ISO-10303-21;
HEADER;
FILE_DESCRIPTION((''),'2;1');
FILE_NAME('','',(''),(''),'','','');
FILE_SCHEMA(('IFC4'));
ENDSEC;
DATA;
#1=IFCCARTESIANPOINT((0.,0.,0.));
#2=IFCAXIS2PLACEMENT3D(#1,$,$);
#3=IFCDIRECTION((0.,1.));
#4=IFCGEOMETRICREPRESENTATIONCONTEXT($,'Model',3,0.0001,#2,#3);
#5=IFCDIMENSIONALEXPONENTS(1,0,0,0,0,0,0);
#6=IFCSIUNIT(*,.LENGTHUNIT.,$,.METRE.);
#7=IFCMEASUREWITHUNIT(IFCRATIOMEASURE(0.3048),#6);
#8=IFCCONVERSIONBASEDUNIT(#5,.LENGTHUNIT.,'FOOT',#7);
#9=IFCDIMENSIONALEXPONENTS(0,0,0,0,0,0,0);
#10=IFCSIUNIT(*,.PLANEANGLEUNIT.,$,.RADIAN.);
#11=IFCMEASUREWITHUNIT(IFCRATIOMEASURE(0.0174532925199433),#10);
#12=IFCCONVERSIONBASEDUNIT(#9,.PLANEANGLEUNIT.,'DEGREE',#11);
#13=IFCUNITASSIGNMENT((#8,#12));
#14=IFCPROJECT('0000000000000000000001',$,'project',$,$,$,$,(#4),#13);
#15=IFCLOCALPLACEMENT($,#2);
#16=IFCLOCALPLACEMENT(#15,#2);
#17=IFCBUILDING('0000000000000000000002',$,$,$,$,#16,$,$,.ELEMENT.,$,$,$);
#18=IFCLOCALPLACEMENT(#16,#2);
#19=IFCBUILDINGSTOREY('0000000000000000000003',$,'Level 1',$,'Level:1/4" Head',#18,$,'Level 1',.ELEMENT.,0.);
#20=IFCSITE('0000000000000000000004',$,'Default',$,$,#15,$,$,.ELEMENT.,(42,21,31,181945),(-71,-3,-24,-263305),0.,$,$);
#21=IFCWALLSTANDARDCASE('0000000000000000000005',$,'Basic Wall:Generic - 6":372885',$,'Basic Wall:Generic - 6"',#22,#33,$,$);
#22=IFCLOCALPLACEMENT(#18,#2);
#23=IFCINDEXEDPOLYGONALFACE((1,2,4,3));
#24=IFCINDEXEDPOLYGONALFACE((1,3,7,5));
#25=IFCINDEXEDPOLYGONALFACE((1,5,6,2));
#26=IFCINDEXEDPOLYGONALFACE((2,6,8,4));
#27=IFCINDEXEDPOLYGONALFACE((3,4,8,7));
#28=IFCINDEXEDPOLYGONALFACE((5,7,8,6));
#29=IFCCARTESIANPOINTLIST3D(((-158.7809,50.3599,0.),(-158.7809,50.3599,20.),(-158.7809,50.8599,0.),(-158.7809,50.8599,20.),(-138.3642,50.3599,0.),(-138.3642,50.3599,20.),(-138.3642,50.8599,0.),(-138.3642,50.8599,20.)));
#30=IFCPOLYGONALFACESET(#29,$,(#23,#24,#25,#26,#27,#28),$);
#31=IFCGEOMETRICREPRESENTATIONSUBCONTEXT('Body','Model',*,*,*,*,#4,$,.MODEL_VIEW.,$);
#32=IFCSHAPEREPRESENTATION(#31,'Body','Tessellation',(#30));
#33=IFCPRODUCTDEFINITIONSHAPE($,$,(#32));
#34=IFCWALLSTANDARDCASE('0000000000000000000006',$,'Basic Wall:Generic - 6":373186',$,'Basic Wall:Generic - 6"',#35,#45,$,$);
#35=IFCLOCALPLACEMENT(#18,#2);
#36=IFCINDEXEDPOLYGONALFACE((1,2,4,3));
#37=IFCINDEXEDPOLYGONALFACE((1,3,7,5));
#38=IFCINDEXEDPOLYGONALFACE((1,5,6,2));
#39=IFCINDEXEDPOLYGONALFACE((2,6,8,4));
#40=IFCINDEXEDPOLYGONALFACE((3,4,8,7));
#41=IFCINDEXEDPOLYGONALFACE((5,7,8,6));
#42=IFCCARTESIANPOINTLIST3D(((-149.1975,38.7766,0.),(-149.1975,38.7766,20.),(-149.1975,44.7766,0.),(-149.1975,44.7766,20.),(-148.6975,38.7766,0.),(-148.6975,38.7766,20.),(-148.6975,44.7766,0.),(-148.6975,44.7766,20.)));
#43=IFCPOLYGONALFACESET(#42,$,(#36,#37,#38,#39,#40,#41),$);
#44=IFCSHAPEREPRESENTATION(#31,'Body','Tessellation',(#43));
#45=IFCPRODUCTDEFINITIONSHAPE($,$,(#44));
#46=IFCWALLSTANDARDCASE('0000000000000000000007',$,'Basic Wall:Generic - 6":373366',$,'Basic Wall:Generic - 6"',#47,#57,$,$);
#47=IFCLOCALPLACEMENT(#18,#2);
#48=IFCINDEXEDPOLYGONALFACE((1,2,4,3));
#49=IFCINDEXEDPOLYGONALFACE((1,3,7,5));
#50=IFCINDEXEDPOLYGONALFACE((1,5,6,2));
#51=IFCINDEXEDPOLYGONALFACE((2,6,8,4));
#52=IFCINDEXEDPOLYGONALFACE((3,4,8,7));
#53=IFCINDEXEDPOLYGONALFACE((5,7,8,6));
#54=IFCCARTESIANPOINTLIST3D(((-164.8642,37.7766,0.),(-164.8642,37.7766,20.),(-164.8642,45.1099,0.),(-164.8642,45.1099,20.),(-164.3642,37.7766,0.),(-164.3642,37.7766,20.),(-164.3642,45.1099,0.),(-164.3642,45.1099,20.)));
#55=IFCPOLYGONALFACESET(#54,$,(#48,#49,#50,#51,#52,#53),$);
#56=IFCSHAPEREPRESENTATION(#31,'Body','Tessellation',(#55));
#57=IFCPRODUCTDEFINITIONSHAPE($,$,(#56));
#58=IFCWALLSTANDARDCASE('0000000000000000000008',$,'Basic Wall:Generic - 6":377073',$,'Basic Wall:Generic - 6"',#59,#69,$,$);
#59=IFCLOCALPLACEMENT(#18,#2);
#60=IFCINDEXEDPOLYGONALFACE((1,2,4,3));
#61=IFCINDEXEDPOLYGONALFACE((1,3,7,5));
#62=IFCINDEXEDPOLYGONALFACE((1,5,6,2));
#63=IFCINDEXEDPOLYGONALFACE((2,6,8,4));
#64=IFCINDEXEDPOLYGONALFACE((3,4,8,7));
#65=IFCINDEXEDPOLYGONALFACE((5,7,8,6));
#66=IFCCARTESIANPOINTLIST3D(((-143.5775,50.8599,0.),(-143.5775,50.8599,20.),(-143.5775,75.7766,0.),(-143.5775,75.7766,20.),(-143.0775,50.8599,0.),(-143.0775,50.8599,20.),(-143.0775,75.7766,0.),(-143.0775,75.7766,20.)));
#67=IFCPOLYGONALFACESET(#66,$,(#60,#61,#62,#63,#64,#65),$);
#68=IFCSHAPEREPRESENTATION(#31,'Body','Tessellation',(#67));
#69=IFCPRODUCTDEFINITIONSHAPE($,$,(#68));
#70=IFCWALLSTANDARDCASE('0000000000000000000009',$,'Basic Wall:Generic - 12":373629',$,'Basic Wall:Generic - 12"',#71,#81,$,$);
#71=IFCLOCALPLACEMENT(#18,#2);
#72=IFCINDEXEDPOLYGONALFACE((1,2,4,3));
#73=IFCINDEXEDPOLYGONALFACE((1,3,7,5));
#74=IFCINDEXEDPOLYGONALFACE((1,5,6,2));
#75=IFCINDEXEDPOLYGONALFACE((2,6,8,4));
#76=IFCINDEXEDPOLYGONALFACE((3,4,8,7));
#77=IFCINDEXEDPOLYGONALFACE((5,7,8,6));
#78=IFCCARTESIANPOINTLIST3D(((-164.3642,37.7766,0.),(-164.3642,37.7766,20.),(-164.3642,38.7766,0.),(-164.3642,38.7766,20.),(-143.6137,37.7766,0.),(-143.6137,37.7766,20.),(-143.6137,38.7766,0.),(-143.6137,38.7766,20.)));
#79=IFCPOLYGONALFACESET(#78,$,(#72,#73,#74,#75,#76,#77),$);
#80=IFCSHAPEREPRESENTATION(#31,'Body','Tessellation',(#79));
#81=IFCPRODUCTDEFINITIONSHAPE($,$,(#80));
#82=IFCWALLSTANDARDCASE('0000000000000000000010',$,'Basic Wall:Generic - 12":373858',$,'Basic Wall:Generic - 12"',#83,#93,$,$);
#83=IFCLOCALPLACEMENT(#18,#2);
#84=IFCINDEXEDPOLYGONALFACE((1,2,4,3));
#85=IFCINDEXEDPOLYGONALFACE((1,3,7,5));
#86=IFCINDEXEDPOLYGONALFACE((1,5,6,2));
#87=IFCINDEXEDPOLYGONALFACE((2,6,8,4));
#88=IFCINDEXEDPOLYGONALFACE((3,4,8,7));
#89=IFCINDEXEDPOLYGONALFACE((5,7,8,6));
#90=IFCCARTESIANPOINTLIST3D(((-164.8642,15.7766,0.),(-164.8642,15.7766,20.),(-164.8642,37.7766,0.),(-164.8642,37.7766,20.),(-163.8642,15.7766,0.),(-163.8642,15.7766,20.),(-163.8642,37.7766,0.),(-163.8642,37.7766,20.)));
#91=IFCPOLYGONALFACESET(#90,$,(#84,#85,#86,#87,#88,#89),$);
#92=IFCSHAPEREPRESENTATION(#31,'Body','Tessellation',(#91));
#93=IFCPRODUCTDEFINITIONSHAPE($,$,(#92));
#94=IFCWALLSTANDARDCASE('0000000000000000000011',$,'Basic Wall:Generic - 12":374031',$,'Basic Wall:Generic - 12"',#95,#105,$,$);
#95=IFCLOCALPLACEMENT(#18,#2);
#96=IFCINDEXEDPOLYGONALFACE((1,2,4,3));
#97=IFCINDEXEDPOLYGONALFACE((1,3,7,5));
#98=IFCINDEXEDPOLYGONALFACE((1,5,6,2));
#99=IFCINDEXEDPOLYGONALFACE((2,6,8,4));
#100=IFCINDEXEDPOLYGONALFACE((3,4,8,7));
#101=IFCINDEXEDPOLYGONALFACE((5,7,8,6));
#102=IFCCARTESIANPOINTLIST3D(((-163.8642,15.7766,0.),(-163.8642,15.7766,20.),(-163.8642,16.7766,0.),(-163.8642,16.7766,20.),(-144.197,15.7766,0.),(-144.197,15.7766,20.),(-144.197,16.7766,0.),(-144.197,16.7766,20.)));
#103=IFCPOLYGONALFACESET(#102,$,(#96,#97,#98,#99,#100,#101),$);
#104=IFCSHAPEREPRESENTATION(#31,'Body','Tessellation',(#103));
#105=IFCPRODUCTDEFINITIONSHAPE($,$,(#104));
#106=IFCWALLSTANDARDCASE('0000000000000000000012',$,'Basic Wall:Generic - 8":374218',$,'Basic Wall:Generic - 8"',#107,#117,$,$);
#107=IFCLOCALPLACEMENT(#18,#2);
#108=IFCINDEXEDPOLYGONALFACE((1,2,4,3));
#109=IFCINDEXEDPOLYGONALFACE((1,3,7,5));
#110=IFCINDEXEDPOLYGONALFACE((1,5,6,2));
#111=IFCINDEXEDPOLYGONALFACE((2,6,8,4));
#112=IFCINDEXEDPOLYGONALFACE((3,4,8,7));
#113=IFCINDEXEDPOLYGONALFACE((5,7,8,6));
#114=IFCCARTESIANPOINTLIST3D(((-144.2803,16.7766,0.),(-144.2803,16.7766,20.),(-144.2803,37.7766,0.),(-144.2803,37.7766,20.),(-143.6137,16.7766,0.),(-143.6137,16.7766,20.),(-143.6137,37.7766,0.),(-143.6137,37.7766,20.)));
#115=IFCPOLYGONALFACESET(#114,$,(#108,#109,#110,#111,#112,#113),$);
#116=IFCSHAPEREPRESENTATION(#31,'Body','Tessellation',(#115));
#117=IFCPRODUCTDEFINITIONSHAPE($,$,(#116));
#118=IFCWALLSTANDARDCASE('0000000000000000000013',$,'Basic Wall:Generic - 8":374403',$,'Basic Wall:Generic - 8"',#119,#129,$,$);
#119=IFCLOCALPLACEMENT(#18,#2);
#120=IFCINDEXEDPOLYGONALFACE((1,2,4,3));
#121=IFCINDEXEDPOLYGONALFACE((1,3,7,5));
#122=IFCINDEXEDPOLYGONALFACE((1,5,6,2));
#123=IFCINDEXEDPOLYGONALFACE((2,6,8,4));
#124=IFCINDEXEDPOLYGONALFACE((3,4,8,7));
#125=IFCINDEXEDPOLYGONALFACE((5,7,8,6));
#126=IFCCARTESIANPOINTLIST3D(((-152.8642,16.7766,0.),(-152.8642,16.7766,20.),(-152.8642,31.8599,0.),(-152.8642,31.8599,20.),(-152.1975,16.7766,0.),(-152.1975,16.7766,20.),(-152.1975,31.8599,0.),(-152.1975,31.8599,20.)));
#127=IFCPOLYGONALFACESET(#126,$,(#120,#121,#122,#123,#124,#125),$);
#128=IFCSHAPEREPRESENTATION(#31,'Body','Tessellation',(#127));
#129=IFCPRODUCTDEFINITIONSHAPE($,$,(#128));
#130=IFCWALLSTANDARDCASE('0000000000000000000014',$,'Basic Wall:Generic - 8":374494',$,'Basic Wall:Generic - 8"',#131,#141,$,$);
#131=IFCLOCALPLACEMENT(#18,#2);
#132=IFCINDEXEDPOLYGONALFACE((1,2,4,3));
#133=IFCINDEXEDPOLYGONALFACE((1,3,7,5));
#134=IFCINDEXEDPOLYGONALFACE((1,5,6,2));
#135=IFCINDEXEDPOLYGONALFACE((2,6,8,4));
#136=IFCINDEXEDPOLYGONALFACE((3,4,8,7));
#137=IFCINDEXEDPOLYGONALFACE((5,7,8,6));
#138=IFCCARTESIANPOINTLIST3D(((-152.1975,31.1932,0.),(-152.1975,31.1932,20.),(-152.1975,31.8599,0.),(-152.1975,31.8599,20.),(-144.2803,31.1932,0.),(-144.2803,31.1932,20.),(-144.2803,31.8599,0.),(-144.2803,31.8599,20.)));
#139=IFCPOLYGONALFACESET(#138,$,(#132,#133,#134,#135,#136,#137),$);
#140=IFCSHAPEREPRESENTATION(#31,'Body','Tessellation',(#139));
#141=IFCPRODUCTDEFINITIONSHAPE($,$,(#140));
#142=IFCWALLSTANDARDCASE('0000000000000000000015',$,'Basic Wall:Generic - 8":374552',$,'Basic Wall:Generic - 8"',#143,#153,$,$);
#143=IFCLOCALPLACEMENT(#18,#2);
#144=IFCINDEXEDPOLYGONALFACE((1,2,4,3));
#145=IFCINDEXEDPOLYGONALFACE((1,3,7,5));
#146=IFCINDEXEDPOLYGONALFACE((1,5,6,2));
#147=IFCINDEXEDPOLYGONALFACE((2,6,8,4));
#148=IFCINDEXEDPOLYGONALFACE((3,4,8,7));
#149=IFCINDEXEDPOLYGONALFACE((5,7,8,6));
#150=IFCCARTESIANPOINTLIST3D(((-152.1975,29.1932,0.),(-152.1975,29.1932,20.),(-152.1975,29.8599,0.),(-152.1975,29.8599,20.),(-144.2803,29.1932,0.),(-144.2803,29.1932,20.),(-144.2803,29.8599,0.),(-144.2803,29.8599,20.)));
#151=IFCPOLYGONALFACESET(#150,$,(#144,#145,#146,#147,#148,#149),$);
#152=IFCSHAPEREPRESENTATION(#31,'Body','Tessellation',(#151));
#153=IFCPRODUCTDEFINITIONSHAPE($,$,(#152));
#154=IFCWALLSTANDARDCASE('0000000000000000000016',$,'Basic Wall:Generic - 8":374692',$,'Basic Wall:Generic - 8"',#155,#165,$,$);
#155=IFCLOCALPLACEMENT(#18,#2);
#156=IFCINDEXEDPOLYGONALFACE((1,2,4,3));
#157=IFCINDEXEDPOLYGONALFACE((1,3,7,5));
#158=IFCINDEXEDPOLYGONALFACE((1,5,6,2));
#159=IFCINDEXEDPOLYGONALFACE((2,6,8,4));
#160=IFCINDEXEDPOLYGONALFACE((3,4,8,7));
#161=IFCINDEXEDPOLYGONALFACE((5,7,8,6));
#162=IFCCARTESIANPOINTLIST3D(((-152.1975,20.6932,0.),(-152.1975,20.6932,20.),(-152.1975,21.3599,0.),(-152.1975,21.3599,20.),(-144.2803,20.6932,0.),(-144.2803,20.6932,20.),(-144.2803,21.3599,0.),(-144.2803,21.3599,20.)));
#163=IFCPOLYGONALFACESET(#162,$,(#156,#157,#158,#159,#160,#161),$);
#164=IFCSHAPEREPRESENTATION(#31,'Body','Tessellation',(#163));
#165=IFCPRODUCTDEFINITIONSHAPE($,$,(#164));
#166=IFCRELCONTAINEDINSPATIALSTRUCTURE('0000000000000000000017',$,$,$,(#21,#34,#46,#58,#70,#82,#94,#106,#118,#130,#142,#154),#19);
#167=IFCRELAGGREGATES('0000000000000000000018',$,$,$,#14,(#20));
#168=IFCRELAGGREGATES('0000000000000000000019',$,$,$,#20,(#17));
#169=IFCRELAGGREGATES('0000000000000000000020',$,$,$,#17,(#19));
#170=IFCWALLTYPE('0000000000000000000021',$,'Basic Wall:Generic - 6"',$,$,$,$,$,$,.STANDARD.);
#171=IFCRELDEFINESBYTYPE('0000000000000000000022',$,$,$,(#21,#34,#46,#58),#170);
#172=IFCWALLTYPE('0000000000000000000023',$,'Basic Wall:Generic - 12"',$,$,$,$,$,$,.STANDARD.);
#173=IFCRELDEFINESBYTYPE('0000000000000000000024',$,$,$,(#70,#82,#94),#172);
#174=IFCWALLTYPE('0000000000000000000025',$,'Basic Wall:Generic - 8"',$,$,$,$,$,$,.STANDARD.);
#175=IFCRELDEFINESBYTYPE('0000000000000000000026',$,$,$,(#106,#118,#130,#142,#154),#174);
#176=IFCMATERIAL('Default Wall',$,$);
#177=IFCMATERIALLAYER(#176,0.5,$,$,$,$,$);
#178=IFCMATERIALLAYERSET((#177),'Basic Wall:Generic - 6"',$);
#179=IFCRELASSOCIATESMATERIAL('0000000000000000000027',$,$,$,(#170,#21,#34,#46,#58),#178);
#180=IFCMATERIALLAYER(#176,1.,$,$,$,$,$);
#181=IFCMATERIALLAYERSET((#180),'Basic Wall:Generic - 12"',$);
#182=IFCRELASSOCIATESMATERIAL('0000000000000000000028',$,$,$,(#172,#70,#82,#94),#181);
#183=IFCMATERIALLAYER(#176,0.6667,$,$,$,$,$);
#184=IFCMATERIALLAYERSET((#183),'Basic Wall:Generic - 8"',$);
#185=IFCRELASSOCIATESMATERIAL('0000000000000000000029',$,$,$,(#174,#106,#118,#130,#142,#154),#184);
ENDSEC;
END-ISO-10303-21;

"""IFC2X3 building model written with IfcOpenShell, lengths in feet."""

from ifc_helpers import new_model, entity, si_unit, converted_unit, direction, frame, frame_2d, origin, place, context, subcontext, project, spatial, rectangle, extrude, material, layer, layer_set, layer_usage, type_object, element, save


model = new_model("IFC2X3")

# Units and contexts
model_context = context("Model", 3, precision=0.0001, world=origin(), true_north=direction((0.0, 1.0)))
body_context = subcontext(model_context, "Body", "Model", "MODEL_VIEW")
ifc_project = project(units=[converted_unit("LENGTHUNIT", "FOOT", entity("IfcRatioMeasure", 0.3048), si_unit("LENGTHUNIT", "METRE"), dimensions=[1, 0, 0, 0, 0, 0, 0]), converted_unit("PLANEANGLEUNIT", "DEGREE", entity("IfcRatioMeasure", 0.0174532925199433), si_unit("PLANEANGLEUNIT", "RADIAN"), dimensions=[0, 0, 0, 0, 0, 0, 0])], contexts=[model_context])

# Site, building, storey
site_placement = place(None, origin())
site = spatial("IfcSite", under=ifc_project, at=site_placement, Name="Default", CompositionType="ELEMENT", RefLatitude=(42, 21, 31, 181945), RefLongitude=(-71, -3, -24, -263305), RefElevation=0.0)
building_placement = place(site_placement, origin())
building = spatial("IfcBuilding", under=site, at=building_placement, CompositionType="ELEMENT")
storey_placement = place(building_placement, origin())
storey = spatial("IfcBuildingStorey", under=building, at=storey_placement, Name="Level 1", ObjectType="Level:1/4\" Head", LongName="Level 1", CompositionType="ELEMENT", Elevation=0.0)

# Walls
ifc_material = material(Name="Default Wall")
ifc_layer_1 = layer(ifc_material, 0.5)
ifc_layer_set_1 = layer_set([ifc_layer_1], Name="Basic Wall:Generic - 6\"")
wall_type_1 = type_object("IfcWallType", Name="Basic Wall:Generic - 6\"", PredefinedType="STANDARD", material=ifc_layer_set_1)
ifc_layer_usage_1 = layer_usage(ifc_layer_set_1, "AXIS2", "NEGATIVE", 0.25)
wall_1_placement = place(storey_placement, frame((-158.7809, 50.6099, 0.0)))
element("IfcWallStandardCase", 1, at=wall_1_placement, inside=storey, type_object=wall_type_1, material=ifc_layer_usage_1, Name="Basic Wall:Generic - 6\":372885", ObjectType="Basic Wall:Generic - 6\"", context=body_context, shape_type="SweptSolid", body=[
    extrude(rectangle(XDim=20.4167, YDim=0.5, at=frame_2d((10.2083, 0.0), x_axis=(-1.0, 0.0))), origin(), (0.0, 0.0, 1.0), 20.0),
])
ifc_layer_usage_2 = layer_usage(ifc_layer_set_1, "AXIS2", "NEGATIVE", 0.25)
wall_2_placement = place(storey_placement, frame((-148.9475, 44.7766, 0.0), z_axis=(0.0, 0.0, 1.0), x_axis=(0.0, -1.0, 0.0)))
element("IfcWallStandardCase", 2, at=wall_2_placement, inside=storey, type_object=wall_type_1, material=ifc_layer_usage_2, Name="Basic Wall:Generic - 6\":373186", ObjectType="Basic Wall:Generic - 6\"", context=body_context, shape_type="SweptSolid", body=[
    extrude(rectangle(XDim=6.0, YDim=0.5, at=frame_2d((3.0, 0.0), x_axis=(-1.0, 0.0))), origin(), (0.0, 0.0, 1.0), 20.0),
])
ifc_layer_usage_3 = layer_usage(ifc_layer_set_1, "AXIS2", "NEGATIVE", 0.25)
wall_3_placement = place(storey_placement, frame((-164.6142, 45.1099, 0.0), z_axis=(0.0, 0.0, 1.0), x_axis=(0.0, -1.0, 0.0)))
element("IfcWallStandardCase", 3, at=wall_3_placement, inside=storey, type_object=wall_type_1, material=ifc_layer_usage_3, Name="Basic Wall:Generic - 6\":373366", ObjectType="Basic Wall:Generic - 6\"", context=body_context, shape_type="SweptSolid", body=[
    extrude(rectangle(XDim=7.3333, YDim=0.5, at=frame_2d((3.6667, 0.0), x_axis=(-1.0, 0.0))), origin(), (0.0, 0.0, 1.0), 20.0),
])
ifc_layer_usage_4 = layer_usage(ifc_layer_set_1, "AXIS2", "NEGATIVE", 0.25)
wall_4_placement = place(storey_placement, frame((-143.3275, 50.8599, 0.0), z_axis=(0.0, 0.0, 1.0), x_axis=(0.0, 1.0, 0.0)))
element("IfcWallStandardCase", 4, at=wall_4_placement, inside=storey, type_object=wall_type_1, material=ifc_layer_usage_4, Name="Basic Wall:Generic - 6\":377073", ObjectType="Basic Wall:Generic - 6\"", context=body_context, shape_type="SweptSolid", body=[
    extrude(rectangle(XDim=24.9167, YDim=0.5, at=frame_2d((12.4583, 0.0), x_axis=(-1.0, 0.0))), origin(), (0.0, 0.0, 1.0), 20.0),
])
ifc_layer_2 = layer(ifc_material, 1.0)
ifc_layer_set_2 = layer_set([ifc_layer_2], Name="Basic Wall:Generic - 12\"")
ifc_layer_usage_5 = layer_usage(ifc_layer_set_2, "AXIS2", "NEGATIVE", 0.5)
wall_type_2 = type_object("IfcWallType", Name="Basic Wall:Generic - 12\"", PredefinedType="STANDARD", material=ifc_layer_set_2)
wall_5_placement = place(storey_placement, frame((-143.6137, 38.2766, 0.0), z_axis=(0.0, 0.0, 1.0), x_axis=(-1.0, 0.0, 0.0)))
element("IfcWallStandardCase", 5, at=wall_5_placement, inside=storey, type_object=wall_type_2, material=ifc_layer_usage_5, Name="Basic Wall:Generic - 12\":373629", ObjectType="Basic Wall:Generic - 12\"", context=body_context, shape_type="SweptSolid", body=[
    extrude(rectangle(XDim=20.7505, YDim=1.0, at=frame_2d((10.3753, 0.0), x_axis=(-1.0, 0.0))), origin(), (0.0, 0.0, 1.0), 20.0),
])
ifc_layer_usage_6 = layer_usage(ifc_layer_set_2, "AXIS2", "NEGATIVE", 0.5)
wall_6_placement = place(storey_placement, frame((-164.3642, 37.7766, 0.0), z_axis=(0.0, 0.0, 1.0), x_axis=(0.0, -1.0, 0.0)))
element("IfcWallStandardCase", 6, at=wall_6_placement, inside=storey, type_object=wall_type_2, material=ifc_layer_usage_6, Name="Basic Wall:Generic - 12\":373858", ObjectType="Basic Wall:Generic - 12\"", context=body_context, shape_type="SweptSolid", body=[
    extrude(rectangle(XDim=22.0, YDim=1.0, at=frame_2d((11.0, 0.0), x_axis=(-1.0, 0.0))), origin(), (0.0, 0.0, 1.0), 20.0),
])
ifc_layer_usage_7 = layer_usage(ifc_layer_set_2, "AXIS2", "NEGATIVE", 0.5)
wall_7_placement = place(storey_placement, frame((-163.8642, 16.2766, 0.0)))
element("IfcWallStandardCase", 7, at=wall_7_placement, inside=storey, type_object=wall_type_2, material=ifc_layer_usage_7, Name="Basic Wall:Generic - 12\":374031", ObjectType="Basic Wall:Generic - 12\"", context=body_context, shape_type="SweptSolid", body=[
    extrude(rectangle(XDim=19.6672, YDim=1.0, at=frame_2d((9.8336, 0.0), x_axis=(-1.0, 0.0))), origin(), (0.0, 0.0, 1.0), 20.0),
])
ifc_layer_3 = layer(ifc_material, 0.6667)
ifc_layer_set_3 = layer_set([ifc_layer_3], Name="Basic Wall:Generic - 8\"")
ifc_layer_usage_8 = layer_usage(ifc_layer_set_3, "AXIS2", "NEGATIVE", 0.3333)
wall_type_3 = type_object("IfcWallType", Name="Basic Wall:Generic - 8\"", PredefinedType="STANDARD", material=ifc_layer_set_3)
wall_8_placement = place(storey_placement, frame((-143.947, 16.7766, 0.0), z_axis=(0.0, 0.0, 1.0), x_axis=(0.0, 1.0, 0.0)))
element("IfcWallStandardCase", 8, at=wall_8_placement, inside=storey, type_object=wall_type_3, material=ifc_layer_usage_8, Name="Basic Wall:Generic - 8\":374218", ObjectType="Basic Wall:Generic - 8\"", context=body_context, shape_type="SweptSolid", body=[
    extrude(rectangle(XDim=21.0, YDim=0.6667, at=frame_2d((10.5, 0.0), x_axis=(-1.0, 0.0))), origin(), (0.0, 0.0, 1.0), 20.0),
])
ifc_layer_usage_9 = layer_usage(ifc_layer_set_3, "AXIS2", "NEGATIVE", 0.3333)
wall_9_placement = place(storey_placement, frame((-152.5309, 31.8599, 0.0), z_axis=(0.0, 0.0, 1.0), x_axis=(0.0, -1.0, 0.0)))
element("IfcWallStandardCase", 9, at=wall_9_placement, inside=storey, type_object=wall_type_3, material=ifc_layer_usage_9, Name="Basic Wall:Generic - 8\":374403", ObjectType="Basic Wall:Generic - 8\"", context=body_context, shape_type="SweptSolid", body=[
    extrude(rectangle(XDim=15.0833, YDim=0.6667, at=frame_2d((7.5417, 0.0), x_axis=(-1.0, 0.0))), origin(), (0.0, 0.0, 1.0), 20.0),
])
ifc_layer_usage_10 = layer_usage(ifc_layer_set_3, "AXIS2", "NEGATIVE", 0.3333)
wall_10_placement = place(storey_placement, frame((-152.1975, 31.5266, 0.0)))
element("IfcWallStandardCase", 10, at=wall_10_placement, inside=storey, type_object=wall_type_3, material=ifc_layer_usage_10, Name="Basic Wall:Generic - 8\":374494", ObjectType="Basic Wall:Generic - 8\"", context=body_context, shape_type="SweptSolid", body=[
    extrude(rectangle(XDim=7.9172, YDim=0.6667, at=frame_2d((3.9586, 0.0), x_axis=(-1.0, 0.0))), origin(), (0.0, 0.0, 1.0), 20.0),
])
ifc_layer_usage_11 = layer_usage(ifc_layer_set_3, "AXIS2", "NEGATIVE", 0.3333)
wall_11_placement = place(storey_placement, frame((-144.2803, 29.5266, 0.0), z_axis=(0.0, 0.0, 1.0), x_axis=(-1.0, 0.0, 0.0)))
element("IfcWallStandardCase", 11, at=wall_11_placement, inside=storey, type_object=wall_type_3, material=ifc_layer_usage_11, Name="Basic Wall:Generic - 8\":374552", ObjectType="Basic Wall:Generic - 8\"", context=body_context, shape_type="SweptSolid", body=[
    extrude(rectangle(XDim=7.9172, YDim=0.6667, at=frame_2d((3.9586, 0.0), x_axis=(-1.0, 0.0))), origin(), (0.0, 0.0, 1.0), 20.0),
])
ifc_layer_usage_12 = layer_usage(ifc_layer_set_3, "AXIS2", "NEGATIVE", 0.3333)
wall_12_placement = place(storey_placement, frame((-144.2803, 21.0266, 0.0), z_axis=(0.0, 0.0, 1.0), x_axis=(-1.0, 0.0, 0.0)))
element("IfcWallStandardCase", 12, at=wall_12_placement, inside=storey, type_object=wall_type_3, material=ifc_layer_usage_12, Name="Basic Wall:Generic - 8\":374692", ObjectType="Basic Wall:Generic - 8\"", context=body_context, shape_type="SweptSolid", body=[
    extrude(rectangle(XDim=7.9172, YDim=0.6667, at=frame_2d((3.9586, 0.0), x_axis=(-1.0, 0.0))), origin(), (0.0, 0.0, 1.0), 20.0),
])

save(model, "model.ifc")
